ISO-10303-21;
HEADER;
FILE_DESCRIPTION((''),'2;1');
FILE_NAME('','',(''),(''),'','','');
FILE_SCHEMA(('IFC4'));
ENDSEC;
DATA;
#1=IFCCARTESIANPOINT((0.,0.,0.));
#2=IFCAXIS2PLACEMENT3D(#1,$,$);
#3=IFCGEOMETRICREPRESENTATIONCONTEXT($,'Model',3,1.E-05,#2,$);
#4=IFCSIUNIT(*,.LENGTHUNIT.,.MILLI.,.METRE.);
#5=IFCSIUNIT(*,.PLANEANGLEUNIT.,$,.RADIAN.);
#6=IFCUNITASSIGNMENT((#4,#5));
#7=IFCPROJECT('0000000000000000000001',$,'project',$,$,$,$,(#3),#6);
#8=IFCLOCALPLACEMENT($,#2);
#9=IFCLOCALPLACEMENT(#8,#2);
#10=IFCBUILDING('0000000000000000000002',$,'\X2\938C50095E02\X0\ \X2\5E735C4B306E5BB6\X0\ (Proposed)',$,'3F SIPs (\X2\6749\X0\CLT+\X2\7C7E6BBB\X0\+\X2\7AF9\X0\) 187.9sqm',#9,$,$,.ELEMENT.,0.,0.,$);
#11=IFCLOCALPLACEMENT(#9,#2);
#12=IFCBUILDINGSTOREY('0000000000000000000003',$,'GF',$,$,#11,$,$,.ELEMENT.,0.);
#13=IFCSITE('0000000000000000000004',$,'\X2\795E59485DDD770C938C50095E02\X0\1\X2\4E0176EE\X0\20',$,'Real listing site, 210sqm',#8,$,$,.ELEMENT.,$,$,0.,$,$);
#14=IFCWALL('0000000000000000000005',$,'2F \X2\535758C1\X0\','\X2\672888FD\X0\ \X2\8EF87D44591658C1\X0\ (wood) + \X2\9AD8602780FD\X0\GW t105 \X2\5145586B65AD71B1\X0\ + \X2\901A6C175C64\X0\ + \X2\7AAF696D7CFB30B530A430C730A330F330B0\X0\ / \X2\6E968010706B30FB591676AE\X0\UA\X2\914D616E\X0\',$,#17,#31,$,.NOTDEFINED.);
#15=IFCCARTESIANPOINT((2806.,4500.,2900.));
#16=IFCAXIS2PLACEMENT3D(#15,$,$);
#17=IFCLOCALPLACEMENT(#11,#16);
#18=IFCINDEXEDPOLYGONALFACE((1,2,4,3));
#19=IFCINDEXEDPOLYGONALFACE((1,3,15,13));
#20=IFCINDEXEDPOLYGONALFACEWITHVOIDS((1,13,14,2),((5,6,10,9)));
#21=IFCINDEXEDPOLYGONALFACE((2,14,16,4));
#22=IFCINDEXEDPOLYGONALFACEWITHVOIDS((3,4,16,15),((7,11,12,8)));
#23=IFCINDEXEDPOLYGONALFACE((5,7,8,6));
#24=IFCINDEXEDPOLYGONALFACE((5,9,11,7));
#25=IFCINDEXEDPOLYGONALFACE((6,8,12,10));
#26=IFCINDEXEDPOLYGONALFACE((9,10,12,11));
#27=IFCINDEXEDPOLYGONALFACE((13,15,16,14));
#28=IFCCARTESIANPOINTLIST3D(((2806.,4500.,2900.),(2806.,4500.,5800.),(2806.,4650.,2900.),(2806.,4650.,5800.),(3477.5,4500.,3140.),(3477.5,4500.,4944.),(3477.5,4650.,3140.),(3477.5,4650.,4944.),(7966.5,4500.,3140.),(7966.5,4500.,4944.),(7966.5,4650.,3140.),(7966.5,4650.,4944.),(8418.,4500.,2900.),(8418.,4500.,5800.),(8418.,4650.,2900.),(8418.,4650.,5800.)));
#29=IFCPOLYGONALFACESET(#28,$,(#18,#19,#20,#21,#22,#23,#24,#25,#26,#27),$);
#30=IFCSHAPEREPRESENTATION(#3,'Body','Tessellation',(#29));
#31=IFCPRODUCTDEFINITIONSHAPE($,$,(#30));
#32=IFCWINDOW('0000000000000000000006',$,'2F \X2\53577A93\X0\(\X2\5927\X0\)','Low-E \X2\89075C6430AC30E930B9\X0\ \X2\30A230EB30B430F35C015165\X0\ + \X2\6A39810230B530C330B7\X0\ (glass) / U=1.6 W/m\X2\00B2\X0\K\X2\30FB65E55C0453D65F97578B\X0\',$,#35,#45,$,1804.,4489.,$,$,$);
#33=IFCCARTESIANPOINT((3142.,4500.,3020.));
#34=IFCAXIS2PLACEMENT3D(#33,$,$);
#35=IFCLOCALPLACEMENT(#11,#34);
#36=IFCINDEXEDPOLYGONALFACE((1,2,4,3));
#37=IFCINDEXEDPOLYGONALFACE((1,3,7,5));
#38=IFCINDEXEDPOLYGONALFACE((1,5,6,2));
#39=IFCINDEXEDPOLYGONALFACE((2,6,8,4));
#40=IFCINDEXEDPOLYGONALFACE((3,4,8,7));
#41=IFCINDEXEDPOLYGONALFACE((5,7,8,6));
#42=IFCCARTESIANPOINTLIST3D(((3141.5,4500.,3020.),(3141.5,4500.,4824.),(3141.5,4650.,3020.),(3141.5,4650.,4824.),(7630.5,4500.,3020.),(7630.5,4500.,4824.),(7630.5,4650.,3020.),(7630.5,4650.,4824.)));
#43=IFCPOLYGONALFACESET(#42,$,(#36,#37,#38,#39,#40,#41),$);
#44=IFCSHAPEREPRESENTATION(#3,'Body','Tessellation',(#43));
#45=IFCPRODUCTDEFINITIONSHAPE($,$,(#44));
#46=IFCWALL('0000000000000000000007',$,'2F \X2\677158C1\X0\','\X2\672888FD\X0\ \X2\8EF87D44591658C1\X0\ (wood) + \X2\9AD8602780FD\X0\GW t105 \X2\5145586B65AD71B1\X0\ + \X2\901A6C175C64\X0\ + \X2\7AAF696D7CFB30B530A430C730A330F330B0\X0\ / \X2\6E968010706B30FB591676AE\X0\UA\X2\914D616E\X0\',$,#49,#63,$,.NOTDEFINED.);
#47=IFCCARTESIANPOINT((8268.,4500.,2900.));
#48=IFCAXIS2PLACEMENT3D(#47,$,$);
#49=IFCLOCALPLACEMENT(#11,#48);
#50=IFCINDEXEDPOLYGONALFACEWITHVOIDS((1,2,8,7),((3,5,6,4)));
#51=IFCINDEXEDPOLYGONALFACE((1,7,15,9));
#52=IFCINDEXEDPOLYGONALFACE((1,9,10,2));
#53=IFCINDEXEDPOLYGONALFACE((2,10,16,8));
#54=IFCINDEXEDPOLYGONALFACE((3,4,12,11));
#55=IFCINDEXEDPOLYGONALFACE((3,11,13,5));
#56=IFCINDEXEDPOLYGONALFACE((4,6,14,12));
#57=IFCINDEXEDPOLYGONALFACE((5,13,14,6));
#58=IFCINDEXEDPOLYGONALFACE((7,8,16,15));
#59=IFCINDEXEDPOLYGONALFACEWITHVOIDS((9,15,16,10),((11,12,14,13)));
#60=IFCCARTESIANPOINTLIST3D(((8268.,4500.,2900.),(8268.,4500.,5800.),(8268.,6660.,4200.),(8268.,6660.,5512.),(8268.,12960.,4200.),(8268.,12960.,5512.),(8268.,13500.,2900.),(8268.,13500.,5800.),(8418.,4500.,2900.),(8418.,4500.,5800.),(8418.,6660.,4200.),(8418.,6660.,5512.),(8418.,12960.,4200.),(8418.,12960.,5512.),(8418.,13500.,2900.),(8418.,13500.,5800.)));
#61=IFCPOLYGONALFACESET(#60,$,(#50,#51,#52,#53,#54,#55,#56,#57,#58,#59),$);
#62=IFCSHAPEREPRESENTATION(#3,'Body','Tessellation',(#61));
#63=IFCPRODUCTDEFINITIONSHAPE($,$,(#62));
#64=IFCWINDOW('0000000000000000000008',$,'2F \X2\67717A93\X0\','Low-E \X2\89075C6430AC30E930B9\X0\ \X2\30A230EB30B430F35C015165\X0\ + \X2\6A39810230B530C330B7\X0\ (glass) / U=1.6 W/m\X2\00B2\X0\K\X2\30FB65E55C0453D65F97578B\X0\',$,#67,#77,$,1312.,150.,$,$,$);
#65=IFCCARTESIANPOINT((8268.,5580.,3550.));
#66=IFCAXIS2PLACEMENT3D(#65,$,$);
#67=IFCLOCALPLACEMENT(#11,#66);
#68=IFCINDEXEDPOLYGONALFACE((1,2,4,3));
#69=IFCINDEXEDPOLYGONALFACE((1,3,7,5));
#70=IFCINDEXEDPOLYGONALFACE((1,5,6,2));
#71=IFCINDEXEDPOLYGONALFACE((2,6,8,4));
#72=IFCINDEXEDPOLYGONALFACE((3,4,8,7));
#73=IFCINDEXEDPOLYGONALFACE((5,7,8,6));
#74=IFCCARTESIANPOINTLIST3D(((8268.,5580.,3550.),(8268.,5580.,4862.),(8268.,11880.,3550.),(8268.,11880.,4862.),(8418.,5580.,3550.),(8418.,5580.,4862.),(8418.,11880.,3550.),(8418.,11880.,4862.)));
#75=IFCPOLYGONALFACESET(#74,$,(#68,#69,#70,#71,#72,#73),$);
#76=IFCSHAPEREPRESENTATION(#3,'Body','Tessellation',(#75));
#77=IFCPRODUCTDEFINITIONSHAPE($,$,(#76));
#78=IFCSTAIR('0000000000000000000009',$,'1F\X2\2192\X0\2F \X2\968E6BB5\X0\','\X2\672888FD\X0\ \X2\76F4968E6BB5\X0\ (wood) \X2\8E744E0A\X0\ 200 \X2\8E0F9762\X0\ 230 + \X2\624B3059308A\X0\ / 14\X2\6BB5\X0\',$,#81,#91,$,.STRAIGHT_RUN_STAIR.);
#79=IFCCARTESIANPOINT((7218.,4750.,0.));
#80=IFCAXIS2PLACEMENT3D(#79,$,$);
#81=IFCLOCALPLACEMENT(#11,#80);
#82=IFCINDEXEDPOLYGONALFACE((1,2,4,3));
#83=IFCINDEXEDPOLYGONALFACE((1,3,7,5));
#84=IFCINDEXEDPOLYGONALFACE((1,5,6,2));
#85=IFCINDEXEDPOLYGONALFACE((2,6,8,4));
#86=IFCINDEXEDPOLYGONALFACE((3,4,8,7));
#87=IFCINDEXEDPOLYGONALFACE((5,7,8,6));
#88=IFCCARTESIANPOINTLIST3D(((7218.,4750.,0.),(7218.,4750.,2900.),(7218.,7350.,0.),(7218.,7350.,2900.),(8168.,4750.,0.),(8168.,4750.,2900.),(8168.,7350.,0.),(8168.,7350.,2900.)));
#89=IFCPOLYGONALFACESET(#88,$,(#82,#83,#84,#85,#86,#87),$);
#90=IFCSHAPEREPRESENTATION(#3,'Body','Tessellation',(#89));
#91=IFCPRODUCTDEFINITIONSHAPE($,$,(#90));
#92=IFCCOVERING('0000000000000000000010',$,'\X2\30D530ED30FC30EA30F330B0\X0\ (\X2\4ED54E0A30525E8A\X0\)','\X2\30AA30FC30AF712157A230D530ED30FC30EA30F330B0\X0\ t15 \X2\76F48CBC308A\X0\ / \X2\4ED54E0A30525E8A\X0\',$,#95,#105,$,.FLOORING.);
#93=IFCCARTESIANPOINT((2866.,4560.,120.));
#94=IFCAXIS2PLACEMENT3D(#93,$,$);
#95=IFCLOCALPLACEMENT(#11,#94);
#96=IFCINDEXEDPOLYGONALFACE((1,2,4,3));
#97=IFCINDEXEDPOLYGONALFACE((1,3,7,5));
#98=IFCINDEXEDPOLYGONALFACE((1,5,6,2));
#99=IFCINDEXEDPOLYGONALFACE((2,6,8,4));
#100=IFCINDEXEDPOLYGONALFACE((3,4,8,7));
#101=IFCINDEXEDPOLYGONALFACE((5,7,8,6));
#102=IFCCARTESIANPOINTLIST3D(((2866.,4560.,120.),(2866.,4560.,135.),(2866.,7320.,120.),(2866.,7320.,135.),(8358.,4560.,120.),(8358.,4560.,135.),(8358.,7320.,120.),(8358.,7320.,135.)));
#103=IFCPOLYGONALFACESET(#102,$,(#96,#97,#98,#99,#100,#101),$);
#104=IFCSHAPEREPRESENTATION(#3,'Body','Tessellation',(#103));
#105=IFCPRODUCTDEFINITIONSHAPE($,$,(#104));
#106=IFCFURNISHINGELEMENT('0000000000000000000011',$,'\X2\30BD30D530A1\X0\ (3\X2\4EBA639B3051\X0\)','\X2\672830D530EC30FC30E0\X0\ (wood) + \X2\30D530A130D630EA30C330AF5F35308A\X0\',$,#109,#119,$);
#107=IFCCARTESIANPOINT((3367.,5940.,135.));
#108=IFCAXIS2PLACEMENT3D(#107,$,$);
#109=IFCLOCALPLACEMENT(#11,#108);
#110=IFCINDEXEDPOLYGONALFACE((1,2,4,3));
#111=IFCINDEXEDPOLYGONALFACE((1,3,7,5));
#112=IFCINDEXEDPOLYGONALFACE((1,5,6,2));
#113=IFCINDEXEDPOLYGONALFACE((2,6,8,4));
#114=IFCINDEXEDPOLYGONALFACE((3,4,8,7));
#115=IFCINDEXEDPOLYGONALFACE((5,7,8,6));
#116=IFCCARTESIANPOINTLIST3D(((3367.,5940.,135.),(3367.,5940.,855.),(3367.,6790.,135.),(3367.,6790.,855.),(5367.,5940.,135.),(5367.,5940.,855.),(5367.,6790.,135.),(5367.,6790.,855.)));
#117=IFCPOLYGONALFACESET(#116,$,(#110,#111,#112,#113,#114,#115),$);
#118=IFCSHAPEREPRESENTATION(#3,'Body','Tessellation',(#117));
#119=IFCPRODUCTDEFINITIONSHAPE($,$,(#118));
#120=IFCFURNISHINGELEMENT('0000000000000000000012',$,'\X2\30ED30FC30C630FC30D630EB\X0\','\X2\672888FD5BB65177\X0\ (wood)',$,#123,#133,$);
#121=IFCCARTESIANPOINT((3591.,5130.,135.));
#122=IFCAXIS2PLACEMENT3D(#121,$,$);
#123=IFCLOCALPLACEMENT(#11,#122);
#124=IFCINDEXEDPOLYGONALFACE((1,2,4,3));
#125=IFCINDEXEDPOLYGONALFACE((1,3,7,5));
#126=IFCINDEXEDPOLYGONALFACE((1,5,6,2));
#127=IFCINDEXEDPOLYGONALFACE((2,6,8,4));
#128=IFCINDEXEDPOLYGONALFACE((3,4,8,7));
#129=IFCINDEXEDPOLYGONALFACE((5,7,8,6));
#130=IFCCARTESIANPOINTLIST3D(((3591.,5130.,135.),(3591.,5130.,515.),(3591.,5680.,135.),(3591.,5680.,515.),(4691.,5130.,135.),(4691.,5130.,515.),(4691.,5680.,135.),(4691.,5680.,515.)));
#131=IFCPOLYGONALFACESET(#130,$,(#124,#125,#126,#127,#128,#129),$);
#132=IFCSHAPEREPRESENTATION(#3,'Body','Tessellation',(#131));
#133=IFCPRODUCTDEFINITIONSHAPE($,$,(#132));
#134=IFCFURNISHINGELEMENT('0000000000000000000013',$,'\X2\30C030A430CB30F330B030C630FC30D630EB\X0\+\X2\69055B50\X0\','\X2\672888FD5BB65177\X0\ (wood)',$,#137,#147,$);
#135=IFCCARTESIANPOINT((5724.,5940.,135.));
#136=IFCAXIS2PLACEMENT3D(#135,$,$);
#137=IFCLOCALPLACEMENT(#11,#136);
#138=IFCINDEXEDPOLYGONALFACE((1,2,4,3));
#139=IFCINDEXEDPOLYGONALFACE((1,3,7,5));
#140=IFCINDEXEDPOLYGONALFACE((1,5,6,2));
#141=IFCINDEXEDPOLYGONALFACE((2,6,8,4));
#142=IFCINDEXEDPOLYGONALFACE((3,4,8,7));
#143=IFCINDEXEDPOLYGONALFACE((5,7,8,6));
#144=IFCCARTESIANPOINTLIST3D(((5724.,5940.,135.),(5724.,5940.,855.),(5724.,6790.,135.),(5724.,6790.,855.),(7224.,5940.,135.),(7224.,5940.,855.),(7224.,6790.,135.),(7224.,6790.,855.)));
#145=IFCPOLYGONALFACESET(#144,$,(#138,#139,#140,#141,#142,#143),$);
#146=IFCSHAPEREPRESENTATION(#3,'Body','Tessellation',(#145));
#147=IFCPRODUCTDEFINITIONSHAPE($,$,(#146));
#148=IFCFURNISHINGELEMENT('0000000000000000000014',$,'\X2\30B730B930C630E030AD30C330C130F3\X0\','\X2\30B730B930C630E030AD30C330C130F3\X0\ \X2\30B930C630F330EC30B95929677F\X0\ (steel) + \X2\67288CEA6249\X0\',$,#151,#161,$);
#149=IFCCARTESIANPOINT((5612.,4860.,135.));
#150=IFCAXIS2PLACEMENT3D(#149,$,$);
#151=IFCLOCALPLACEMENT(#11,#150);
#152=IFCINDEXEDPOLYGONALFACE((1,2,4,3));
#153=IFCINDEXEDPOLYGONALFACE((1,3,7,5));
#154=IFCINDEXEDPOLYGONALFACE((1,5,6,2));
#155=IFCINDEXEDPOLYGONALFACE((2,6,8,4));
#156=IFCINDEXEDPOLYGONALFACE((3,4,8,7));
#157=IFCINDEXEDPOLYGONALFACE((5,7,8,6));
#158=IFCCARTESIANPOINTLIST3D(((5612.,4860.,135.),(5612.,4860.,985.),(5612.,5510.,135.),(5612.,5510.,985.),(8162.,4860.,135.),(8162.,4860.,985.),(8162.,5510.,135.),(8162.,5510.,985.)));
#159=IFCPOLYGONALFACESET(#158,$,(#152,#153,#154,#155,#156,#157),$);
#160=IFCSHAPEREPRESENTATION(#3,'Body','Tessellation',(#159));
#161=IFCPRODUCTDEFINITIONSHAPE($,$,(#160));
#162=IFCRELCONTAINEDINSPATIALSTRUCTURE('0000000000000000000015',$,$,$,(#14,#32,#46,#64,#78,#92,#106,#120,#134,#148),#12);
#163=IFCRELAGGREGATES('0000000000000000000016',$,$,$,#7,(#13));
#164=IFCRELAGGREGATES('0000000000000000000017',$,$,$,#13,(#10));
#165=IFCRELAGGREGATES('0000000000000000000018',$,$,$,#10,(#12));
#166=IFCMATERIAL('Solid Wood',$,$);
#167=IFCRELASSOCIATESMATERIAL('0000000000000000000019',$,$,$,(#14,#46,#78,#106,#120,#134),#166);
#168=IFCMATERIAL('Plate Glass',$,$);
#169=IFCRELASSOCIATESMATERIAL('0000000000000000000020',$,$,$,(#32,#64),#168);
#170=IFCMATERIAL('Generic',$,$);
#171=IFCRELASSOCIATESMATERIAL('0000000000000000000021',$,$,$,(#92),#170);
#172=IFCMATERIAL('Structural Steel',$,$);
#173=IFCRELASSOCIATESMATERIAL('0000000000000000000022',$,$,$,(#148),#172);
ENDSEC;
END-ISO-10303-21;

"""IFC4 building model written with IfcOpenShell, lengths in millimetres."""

from ifc_helpers import new_model, si_unit, frame, frame_2d, origin, place, context, project, spatial, rectangle, extrude, material, element, fill, save


model = new_model("IFC4")

# Units and contexts
model_context = context("Model", 3, precision=1e-05, world=origin())
ifc_project = project(units=[si_unit("LENGTHUNIT", "METRE", prefix="MILLI"), si_unit("PLANEANGLEUNIT", "RADIAN")], contexts=[model_context])

# Site, building, storey
site_placement = place(None, origin())
site = spatial("IfcSite", under=ifc_project, at=site_placement, Name="神奈川県鎌倉市1丁目20", ObjectType="Real listing site, 210sqm", CompositionType="ELEMENT", RefElevation=0.0)
building_placement = place(site_placement, origin())
building = spatial("IfcBuilding", under=site, at=building_placement, Name="鎌倉市 平屋の家 (Proposed)", ObjectType="3F SIPs (杉CLT+籾殻+竹) 187.9sqm", CompositionType="ELEMENT", ElevationOfRefHeight=0.0, ElevationOfTerrain=0.0)
storey_placement = place(building_placement, origin())
storey = spatial("IfcBuildingStorey", under=building, at=storey_placement, Name="GF", CompositionType="ELEMENT", Elevation=0.0)

# Shared definitions
ifc_material_1 = material(Name="Solid Wood")

# Shared definitions
ifc_material_2 = material(Name="Plate Glass")

# Walls, openings, windows
wall_1_placement = place(storey_placement, frame((2806.0, 4500.0, 2900.0)))
wall_1 = element("IfcWall", 1, at=wall_1_placement, inside=storey, material=ifc_material_1, Name="2F 南壁", Description="木製 軸組外壁 (wood) + 高性能GW t105 充填断熱 + 通気層 + 窯業系サイディング / 準耐火・外皮UA配慮", PredefinedType="NOTDEFINED", context=model_context, shape_type="SweptSolid", body=[
    extrude(rectangle(XDim=5612.0, YDim=150.0, at=frame_2d((2806.0, 75.0))), frame((2806.0, 4500.0, 2900.0)), (0.0, 0.0, 1.0), 2900.0),
])
opening_1_placement = place(storey_placement, frame((3142.0, 4500.0, 3020.0)))
opening_1 = element("IfcOpeningElement", 2, at=opening_1_placement, cuts=wall_1, PredefinedType="NOTDEFINED", context=model_context, shape_type="SweptSolid", body=[
    extrude(rectangle(XDim=4489.0, YDim=150.0, at=frame_2d((2244.0, 75.0))), frame((3142.0, 4500.0, 3020.0)), (0.0, 0.0, 1.0), 1804.0),
])
window_1_placement = place(storey_placement, frame((3142.0, 4500.0, 3020.0)))
window_1 = element("IfcWindow", 3, at=window_1_placement, inside=storey, material=ifc_material_2, Name="2F 南窓(大)", Description="Low-E 複層ガラス アルゴン封入 + 樹脂サッシ (glass) / U=1.6 W/m²K・日射取得型", OverallHeight=1804.0, OverallWidth=4489.0, context=model_context, shape_type="SweptSolid", body=[
    extrude(rectangle(XDim=4489.0, YDim=150.0, at=frame_2d((2244.0, 75.0))), frame((3142.0, 4500.0, 3020.0)), (0.0, 0.0, 1.0), 1804.0),
])
fill(opening_1, window_1)
wall_2_placement = place(storey_placement, frame((8268.0, 4500.0, 2900.0)))
wall_2 = element("IfcWall", 4, at=wall_2_placement, inside=storey, material=ifc_material_1, Name="2F 東壁", Description="木製 軸組外壁 (wood) + 高性能GW t105 充填断熱 + 通気層 + 窯業系サイディング / 準耐火・外皮UA配慮", PredefinedType="NOTDEFINED", context=model_context, shape_type="SweptSolid", body=[
    extrude(rectangle(XDim=150.0, YDim=9000.0, at=frame_2d((75.0, 4500.0))), frame((8268.0, 4500.0, 2900.0)), (0.0, 0.0, 1.0), 2900.0),
])
opening_2_placement = place(storey_placement, frame((8268.0, 5580.0, 3550.0)))
opening_2 = element("IfcOpeningElement", 5, at=opening_2_placement, cuts=wall_2, PredefinedType="NOTDEFINED", context=model_context, shape_type="SweptSolid", body=[
    extrude(rectangle(XDim=150.0, YDim=6300.0, at=frame_2d((75.0, 3150.0))), frame((8268.0, 5580.0, 3550.0)), (0.0, 0.0, 1.0), 1312.0),
])
window_2_placement = place(storey_placement, frame((8268.0, 5580.0, 3550.0)))
window_2 = element("IfcWindow", 6, at=window_2_placement, inside=storey, material=ifc_material_2, Name="2F 東窓", Description="Low-E 複層ガラス アルゴン封入 + 樹脂サッシ (glass) / U=1.6 W/m²K・日射取得型", OverallHeight=1312.0, OverallWidth=150.0, context=model_context, shape_type="SweptSolid", body=[
    extrude(rectangle(XDim=150.0, YDim=6300.0, at=frame_2d((75.0, 3150.0))), frame((8268.0, 5580.0, 3550.0)), (0.0, 0.0, 1.0), 1312.0),
])
fill(opening_2, window_2)

# Stair
stair_placement = place(storey_placement, frame((7218.0, 4750.0, 0.0)))
element("IfcStair", 7, at=stair_placement, inside=storey, material=ifc_material_1, Name="1F→2F 階段", Description="木製 直階段 (wood) 蹴上 200 踏面 230 + 手すり / 14段", PredefinedType="STRAIGHT_RUN_STAIR", context=model_context, shape_type="SweptSolid", body=[
    extrude(rectangle(XDim=950.0, YDim=2600.0, at=frame_2d((475.0, 1300.0))), frame((7218.0, 4750.0, 0.0)), (0.0, 0.0, 1.0), 2900.0),
])

# Covering
ifc_material_3 = material(Name="Generic")
covering_placement = place(storey_placement, frame((2866.0, 4560.0, 120.0)))
element("IfcCovering", 8, at=covering_placement, inside=storey, material=ifc_material_3, Name="フローリング (仕上げ床)", Description="オーク無垢フローリング t15 直貼り / 仕上げ床", PredefinedType="FLOORING", context=model_context, shape_type="SweptSolid", body=[
    extrude(rectangle(XDim=5492.0, YDim=2760.0, at=frame_2d((2746.0, 1380.0))), frame((2866.0, 4560.0, 120.0)), (0.0, 0.0, 1.0), 15.0),
])

# Furnishing elements
furnishing_1_placement = place(storey_placement, frame((3367.0, 5940.0, 135.0)))
element("IfcFurnishingElement", 9, at=furnishing_1_placement, inside=storey, material=ifc_material_1, Name="ソファ (3人掛け)", Description="木フレーム (wood) + ファブリック張り", context=model_context, shape_type="SweptSolid", body=[
    extrude(rectangle(XDim=2000.0, YDim=850.0, at=frame_2d((1000.0, 425.0))), frame((3367.0, 5940.0, 135.0)), (0.0, 0.0, 1.0), 720.0),
])
furnishing_2_placement = place(storey_placement, frame((3591.0, 5130.0, 135.0)))
element("IfcFurnishingElement", 10, at=furnishing_2_placement, inside=storey, material=ifc_material_1, Name="ローテーブル", Description="木製家具 (wood)", context=model_context, shape_type="SweptSolid", body=[
    extrude(rectangle(XDim=1100.0, YDim=550.0, at=frame_2d((550.0, 275.0))), frame((3591.0, 5130.0, 135.0)), (0.0, 0.0, 1.0), 380.0),
])
furnishing_3_placement = place(storey_placement, frame((5724.0, 5940.0, 135.0)))
element("IfcFurnishingElement", 11, at=furnishing_3_placement, inside=storey, material=ifc_material_1, Name="ダイニングテーブル+椅子", Description="木製家具 (wood)", context=model_context, shape_type="SweptSolid", body=[
    extrude(rectangle(XDim=1500.0, YDim=850.0, at=frame_2d((750.0, 425.0))), frame((5724.0, 5940.0, 135.0)), (0.0, 0.0, 1.0), 720.0),
])
ifc_material_4 = material(Name="Structural Steel")
furnishing_4_placement = place(storey_placement, frame((5612.0, 4860.0, 135.0)))
element("IfcFurnishingElement", 12, at=furnishing_4_placement, inside=storey, material=ifc_material_4, Name="システムキッチン", Description="システムキッチン ステンレス天板 (steel) + 木質扉", context=model_context, shape_type="SweptSolid", body=[
    extrude(rectangle(XDim=2550.0, YDim=650.0, at=frame_2d((1275.0, 325.0))), frame((5612.0, 4860.0, 135.0)), (0.0, 0.0, 1.0), 850.0),
])

save(model, "model.ifc")
